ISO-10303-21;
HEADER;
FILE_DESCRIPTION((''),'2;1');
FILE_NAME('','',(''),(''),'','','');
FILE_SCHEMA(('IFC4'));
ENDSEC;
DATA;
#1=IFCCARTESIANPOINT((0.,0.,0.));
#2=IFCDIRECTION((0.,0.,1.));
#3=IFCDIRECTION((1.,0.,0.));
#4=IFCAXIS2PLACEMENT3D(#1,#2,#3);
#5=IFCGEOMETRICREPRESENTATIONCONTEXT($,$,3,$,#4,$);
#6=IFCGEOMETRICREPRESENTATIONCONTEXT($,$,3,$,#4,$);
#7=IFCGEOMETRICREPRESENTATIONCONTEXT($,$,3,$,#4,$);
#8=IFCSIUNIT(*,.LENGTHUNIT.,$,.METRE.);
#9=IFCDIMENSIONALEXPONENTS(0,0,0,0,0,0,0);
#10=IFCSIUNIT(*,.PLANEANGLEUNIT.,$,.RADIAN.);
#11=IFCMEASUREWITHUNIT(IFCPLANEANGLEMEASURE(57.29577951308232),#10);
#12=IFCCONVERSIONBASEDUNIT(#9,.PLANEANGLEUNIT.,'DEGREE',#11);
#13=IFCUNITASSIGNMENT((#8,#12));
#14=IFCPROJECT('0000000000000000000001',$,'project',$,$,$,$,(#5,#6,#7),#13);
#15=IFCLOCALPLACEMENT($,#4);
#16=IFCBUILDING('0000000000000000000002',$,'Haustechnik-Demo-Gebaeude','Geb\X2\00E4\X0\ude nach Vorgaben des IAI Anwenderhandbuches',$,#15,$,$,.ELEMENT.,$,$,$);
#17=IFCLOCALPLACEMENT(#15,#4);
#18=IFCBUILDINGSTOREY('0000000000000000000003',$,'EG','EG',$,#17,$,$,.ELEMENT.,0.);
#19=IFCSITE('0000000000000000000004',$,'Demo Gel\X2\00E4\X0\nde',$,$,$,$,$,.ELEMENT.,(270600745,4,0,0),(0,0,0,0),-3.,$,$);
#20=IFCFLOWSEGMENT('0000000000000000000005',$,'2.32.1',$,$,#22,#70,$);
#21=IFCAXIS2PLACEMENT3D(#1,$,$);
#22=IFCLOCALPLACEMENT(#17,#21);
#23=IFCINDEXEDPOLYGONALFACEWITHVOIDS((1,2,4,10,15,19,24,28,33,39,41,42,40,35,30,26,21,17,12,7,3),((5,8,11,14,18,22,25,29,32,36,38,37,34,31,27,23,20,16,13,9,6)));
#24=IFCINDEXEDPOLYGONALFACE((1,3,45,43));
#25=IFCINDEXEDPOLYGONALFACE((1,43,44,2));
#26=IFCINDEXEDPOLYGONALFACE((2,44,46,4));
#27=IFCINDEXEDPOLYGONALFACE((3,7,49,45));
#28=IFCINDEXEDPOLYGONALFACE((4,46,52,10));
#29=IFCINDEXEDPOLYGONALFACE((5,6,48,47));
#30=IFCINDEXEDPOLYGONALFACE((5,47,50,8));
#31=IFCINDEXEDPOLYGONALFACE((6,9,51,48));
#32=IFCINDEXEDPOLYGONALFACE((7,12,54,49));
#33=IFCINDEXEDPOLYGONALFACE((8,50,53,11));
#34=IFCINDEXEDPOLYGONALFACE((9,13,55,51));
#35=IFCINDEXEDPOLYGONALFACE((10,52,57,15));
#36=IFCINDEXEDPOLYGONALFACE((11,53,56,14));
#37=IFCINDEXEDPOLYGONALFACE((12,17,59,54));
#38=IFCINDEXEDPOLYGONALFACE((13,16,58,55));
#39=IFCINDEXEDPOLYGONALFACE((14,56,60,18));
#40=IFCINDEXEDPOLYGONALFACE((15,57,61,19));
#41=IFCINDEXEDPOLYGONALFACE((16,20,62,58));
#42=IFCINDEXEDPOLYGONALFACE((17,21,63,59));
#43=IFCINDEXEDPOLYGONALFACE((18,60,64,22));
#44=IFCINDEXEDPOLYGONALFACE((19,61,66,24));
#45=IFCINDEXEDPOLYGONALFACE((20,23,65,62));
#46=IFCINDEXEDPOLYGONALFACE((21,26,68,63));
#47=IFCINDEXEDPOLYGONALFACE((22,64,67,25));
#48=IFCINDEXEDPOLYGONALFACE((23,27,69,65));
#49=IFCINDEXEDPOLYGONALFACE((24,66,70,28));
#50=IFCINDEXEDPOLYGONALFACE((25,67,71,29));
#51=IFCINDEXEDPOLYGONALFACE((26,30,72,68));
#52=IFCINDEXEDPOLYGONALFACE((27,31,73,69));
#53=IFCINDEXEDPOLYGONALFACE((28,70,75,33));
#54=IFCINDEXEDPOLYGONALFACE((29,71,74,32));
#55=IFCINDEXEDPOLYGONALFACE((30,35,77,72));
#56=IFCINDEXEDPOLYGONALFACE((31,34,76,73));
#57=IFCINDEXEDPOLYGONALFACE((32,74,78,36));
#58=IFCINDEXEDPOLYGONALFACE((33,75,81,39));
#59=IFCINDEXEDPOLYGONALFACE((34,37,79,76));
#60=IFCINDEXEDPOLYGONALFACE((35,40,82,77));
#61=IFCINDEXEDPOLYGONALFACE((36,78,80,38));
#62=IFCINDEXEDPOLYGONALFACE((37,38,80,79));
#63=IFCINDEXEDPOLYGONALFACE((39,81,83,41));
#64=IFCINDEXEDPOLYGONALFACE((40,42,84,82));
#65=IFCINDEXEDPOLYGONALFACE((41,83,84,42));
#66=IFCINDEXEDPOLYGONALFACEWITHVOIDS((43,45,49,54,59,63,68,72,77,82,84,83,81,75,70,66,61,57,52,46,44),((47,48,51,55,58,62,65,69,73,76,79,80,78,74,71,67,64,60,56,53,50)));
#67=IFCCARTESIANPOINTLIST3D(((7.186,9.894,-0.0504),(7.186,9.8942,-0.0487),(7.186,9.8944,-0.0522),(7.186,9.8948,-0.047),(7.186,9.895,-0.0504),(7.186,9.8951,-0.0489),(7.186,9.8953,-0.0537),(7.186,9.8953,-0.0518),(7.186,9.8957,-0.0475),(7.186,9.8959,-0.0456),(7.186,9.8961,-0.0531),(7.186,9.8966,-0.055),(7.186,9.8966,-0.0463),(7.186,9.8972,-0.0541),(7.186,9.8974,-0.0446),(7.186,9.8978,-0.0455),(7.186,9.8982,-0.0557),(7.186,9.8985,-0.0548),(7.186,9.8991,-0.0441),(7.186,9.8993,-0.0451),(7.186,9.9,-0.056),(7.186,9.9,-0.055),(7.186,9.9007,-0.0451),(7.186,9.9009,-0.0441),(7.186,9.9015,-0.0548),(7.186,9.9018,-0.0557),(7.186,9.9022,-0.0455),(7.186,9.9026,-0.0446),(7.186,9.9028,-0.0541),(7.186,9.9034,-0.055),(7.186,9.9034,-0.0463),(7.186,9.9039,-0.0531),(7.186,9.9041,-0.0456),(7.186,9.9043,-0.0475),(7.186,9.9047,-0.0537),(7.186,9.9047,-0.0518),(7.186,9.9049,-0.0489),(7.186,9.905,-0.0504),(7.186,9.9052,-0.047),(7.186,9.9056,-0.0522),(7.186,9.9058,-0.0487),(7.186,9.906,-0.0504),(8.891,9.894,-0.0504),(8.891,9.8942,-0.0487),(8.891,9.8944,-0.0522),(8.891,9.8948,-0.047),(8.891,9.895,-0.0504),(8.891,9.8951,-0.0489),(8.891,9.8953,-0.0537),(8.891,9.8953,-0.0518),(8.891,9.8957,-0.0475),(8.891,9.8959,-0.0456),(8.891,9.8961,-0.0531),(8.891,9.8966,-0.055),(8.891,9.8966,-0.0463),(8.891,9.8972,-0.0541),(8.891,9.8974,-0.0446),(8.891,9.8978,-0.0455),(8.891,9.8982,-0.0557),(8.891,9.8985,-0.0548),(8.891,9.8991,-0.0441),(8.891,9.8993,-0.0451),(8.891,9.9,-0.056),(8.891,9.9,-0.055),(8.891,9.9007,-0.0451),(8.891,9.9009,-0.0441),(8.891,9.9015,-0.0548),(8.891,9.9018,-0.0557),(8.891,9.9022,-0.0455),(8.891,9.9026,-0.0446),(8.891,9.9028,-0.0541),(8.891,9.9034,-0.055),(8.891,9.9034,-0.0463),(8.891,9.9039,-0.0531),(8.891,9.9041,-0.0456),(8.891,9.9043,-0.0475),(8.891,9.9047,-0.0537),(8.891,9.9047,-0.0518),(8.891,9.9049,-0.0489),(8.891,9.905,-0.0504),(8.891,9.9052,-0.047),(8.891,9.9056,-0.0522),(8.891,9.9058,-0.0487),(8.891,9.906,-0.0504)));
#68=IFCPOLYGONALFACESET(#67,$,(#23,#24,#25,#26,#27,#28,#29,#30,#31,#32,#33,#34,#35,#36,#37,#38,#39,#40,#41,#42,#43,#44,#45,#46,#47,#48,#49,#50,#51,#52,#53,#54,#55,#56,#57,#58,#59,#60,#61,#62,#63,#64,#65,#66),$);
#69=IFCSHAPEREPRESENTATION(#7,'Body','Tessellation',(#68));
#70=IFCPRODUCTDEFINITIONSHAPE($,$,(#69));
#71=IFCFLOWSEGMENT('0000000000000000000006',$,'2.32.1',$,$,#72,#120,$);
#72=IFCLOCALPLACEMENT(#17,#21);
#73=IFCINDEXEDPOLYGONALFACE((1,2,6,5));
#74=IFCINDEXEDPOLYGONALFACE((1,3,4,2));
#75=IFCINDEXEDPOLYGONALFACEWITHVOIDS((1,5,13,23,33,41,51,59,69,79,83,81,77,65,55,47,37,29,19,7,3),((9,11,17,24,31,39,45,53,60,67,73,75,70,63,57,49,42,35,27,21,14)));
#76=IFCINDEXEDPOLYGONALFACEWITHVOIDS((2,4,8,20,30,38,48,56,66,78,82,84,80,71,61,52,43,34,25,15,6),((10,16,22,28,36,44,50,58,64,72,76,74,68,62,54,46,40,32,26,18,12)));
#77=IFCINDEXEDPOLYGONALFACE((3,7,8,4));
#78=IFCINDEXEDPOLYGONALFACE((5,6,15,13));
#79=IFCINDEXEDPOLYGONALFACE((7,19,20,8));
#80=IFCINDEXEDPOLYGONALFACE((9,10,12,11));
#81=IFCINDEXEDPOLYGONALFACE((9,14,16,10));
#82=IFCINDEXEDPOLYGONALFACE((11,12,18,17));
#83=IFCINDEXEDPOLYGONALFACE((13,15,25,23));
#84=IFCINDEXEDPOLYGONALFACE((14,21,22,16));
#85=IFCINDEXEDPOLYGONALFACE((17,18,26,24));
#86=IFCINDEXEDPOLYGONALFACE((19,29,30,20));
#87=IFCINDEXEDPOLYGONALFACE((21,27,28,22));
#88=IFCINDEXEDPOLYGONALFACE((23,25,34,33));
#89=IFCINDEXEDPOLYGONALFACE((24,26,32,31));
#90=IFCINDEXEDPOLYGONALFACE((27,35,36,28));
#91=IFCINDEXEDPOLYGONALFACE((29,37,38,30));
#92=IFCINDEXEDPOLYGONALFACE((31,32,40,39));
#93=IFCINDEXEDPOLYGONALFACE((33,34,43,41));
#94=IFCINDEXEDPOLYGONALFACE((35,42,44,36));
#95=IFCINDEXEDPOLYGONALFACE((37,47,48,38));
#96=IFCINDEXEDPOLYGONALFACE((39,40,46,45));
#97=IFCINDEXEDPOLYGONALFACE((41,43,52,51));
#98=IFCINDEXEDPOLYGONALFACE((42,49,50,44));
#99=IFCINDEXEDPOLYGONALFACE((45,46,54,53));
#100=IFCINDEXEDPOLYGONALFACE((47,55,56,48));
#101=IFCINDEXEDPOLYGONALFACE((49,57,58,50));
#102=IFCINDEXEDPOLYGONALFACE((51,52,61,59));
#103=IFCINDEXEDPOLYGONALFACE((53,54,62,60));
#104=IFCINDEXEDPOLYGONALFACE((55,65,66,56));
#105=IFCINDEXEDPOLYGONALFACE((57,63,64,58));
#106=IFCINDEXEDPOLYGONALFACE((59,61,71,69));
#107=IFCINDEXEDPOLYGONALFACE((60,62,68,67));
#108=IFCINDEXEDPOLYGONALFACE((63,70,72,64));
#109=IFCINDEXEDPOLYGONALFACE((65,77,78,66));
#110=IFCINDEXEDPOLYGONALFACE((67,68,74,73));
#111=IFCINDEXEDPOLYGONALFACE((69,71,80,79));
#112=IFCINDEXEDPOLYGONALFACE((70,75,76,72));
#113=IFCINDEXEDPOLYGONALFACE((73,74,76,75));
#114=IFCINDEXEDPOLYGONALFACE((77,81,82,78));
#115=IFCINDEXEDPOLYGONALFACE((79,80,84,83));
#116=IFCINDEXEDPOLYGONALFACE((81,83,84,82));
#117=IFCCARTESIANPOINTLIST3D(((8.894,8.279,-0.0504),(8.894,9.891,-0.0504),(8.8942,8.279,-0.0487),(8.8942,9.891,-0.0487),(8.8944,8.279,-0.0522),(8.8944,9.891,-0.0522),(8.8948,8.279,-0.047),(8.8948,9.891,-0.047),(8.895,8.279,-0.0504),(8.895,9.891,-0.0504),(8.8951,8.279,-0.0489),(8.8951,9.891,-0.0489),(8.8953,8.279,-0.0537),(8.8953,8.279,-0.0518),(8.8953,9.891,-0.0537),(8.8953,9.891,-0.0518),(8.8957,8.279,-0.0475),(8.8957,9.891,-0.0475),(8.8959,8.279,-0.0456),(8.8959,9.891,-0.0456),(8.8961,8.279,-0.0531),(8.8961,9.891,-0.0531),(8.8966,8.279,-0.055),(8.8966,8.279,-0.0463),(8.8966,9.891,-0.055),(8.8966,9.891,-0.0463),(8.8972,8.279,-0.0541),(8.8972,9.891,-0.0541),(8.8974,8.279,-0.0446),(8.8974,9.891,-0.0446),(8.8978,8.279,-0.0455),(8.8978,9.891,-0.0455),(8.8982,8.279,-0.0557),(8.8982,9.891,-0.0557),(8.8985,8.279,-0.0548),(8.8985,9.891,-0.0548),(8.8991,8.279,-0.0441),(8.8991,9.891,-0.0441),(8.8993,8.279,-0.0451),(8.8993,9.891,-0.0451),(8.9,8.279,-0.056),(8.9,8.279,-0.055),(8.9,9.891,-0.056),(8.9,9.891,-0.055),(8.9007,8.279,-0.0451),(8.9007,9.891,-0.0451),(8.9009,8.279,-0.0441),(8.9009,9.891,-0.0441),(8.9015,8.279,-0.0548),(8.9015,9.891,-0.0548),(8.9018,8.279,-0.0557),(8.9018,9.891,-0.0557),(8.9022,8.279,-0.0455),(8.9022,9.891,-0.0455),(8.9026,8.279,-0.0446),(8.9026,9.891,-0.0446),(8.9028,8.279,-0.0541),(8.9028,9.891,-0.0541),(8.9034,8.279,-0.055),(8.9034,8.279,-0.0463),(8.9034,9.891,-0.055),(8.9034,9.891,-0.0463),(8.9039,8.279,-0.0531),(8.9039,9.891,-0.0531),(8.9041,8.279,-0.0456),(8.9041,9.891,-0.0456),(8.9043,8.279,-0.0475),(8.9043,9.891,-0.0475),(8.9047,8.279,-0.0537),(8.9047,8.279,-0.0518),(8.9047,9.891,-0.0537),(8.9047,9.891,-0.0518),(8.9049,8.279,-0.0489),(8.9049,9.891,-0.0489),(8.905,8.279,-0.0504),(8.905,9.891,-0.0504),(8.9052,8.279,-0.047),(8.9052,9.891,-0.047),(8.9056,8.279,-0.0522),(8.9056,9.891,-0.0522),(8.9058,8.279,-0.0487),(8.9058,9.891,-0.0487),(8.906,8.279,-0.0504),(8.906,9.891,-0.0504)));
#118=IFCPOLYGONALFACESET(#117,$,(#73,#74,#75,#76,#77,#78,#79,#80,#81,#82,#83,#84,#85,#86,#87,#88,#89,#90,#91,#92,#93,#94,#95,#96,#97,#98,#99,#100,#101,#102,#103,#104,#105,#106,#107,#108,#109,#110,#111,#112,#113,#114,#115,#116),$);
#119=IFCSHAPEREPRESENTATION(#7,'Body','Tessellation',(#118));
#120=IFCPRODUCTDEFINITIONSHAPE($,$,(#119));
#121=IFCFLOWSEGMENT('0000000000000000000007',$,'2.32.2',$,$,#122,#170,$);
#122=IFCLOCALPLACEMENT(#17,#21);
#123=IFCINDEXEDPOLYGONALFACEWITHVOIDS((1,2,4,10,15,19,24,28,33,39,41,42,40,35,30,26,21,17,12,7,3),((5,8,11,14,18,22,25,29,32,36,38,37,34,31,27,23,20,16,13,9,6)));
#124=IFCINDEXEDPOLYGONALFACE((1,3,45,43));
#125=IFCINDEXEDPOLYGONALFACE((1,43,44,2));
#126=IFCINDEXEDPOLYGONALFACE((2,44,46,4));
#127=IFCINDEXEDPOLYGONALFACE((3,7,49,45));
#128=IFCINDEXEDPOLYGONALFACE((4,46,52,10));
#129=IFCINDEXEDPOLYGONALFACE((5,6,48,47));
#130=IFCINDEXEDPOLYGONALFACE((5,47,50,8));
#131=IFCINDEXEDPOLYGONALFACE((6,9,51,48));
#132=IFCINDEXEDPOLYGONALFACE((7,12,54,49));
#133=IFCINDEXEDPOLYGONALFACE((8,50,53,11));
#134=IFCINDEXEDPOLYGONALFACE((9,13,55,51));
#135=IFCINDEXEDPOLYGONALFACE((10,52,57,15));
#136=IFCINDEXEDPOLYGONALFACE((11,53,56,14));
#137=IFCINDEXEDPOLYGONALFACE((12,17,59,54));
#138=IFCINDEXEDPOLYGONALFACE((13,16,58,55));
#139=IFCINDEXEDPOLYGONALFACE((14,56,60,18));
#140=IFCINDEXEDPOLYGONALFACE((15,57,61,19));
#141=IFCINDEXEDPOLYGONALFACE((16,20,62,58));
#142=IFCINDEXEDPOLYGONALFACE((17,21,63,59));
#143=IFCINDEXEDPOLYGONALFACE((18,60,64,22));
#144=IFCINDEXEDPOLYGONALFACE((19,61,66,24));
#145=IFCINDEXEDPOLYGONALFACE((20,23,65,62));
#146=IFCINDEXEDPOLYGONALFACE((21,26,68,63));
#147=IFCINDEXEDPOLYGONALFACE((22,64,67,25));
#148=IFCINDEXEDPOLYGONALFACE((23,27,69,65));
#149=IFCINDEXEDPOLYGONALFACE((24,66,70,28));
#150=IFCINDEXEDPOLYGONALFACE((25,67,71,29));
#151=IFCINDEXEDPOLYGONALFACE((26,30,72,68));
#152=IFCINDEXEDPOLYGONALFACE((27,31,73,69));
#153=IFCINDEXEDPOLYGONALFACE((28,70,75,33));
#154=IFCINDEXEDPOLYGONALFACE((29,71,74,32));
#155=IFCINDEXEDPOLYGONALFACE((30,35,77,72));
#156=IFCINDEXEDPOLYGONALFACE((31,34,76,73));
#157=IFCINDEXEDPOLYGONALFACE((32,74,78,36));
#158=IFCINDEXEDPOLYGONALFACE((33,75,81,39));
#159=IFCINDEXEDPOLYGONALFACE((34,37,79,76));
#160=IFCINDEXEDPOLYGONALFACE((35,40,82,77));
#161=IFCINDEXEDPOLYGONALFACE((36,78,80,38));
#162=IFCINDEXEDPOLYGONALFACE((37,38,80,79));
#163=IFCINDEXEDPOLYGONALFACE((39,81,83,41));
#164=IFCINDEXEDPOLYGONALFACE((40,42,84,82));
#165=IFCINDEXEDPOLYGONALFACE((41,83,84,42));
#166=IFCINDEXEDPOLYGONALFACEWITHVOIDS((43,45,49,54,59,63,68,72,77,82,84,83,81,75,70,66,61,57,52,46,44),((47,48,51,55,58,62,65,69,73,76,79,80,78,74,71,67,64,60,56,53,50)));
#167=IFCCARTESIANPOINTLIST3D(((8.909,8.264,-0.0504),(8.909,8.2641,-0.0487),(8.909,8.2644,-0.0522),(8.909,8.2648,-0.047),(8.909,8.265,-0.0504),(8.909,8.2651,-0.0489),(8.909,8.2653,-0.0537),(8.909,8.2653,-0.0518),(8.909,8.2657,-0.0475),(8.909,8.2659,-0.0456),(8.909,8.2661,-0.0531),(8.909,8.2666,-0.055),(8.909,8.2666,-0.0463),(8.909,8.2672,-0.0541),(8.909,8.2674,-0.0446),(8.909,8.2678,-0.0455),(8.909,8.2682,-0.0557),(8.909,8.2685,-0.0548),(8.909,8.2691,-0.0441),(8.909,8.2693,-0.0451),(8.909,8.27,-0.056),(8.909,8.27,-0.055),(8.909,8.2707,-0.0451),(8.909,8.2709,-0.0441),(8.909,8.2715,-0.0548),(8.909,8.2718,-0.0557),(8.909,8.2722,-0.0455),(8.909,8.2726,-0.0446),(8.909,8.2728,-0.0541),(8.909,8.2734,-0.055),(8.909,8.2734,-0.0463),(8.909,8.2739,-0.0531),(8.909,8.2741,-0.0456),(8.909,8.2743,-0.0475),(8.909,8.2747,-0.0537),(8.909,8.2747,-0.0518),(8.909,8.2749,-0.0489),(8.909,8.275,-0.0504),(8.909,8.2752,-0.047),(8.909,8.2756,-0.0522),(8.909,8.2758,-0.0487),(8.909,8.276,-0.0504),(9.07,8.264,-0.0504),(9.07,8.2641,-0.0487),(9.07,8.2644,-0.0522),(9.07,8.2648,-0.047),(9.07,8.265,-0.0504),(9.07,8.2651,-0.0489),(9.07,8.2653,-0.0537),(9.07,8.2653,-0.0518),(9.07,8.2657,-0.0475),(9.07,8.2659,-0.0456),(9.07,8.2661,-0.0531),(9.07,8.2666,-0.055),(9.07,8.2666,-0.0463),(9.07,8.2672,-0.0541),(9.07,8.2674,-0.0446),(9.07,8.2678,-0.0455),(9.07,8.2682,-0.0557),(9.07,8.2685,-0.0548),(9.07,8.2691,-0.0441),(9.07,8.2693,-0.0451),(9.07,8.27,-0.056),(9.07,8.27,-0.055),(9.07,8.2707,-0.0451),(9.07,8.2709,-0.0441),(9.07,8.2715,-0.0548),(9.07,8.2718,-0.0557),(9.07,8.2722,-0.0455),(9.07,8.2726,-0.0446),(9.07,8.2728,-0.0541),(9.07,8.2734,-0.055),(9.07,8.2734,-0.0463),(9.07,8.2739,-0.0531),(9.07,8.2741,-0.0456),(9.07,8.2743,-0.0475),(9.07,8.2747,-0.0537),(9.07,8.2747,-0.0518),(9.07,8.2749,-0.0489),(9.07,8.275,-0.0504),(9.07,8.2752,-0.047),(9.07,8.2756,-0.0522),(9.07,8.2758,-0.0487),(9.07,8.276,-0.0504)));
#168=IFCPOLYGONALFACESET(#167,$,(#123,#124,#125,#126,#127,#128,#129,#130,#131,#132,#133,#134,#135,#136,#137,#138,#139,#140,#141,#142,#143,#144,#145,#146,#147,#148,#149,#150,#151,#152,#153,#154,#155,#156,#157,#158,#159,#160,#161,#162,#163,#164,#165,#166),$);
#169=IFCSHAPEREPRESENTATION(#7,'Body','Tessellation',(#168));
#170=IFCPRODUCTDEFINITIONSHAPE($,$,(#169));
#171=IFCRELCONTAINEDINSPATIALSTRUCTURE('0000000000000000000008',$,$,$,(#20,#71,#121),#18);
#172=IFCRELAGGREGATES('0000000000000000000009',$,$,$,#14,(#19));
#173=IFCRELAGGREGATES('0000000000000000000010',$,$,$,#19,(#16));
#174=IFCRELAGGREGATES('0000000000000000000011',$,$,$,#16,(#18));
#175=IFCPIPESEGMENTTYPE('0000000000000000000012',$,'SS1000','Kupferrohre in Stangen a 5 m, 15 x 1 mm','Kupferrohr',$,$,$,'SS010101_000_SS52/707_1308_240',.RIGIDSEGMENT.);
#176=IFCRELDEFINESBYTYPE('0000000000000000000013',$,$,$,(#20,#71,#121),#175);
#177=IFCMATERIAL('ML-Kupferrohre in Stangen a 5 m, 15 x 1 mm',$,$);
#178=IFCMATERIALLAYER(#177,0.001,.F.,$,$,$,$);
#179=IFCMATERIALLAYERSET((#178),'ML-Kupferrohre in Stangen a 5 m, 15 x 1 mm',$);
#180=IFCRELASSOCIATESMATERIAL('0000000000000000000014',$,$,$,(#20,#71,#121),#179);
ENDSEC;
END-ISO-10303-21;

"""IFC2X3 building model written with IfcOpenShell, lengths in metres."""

from ifc_helpers import new_model, entity, si_unit, converted_unit, frame, origin_with_axes, origin_2d_with_axis, place, context, project, spatial, hollow_circle, extrude, material, layer, layer_set, layer_usage, type_object, element, save


model = new_model("IFC2X3")

# Units and contexts
context_of_model_1 = context(None, 3, world=origin_with_axes())
context_of_model_2 = context(None, 3, world=origin_with_axes())
context_of_model_3 = context(None, 3, world=origin_with_axes())
ifc_project = project(units=[si_unit("LENGTHUNIT", "METRE"), converted_unit("PLANEANGLEUNIT", "DEGREE", entity("IfcPlaneAngleMeasure", 57.29577951308232), si_unit("PLANEANGLEUNIT", "RADIAN"), dimensions=[0, 0, 0, 0, 0, 0, 0])], contexts=[context_of_model_1, context_of_model_2, context_of_model_3])

# Site, building, storey
site = spatial("IfcSite", under=ifc_project, Name="Demo Gelände", CompositionType="ELEMENT", RefLatitude=(270600745, 4, 0, 0), RefLongitude=(0, 0, 0, 0), RefElevation=-3.0)
building_placement = place(None, origin_with_axes())
building = spatial("IfcBuilding", under=site, at=building_placement, Name="Haustechnik-Demo-Gebaeude", Description="Gebäude nach Vorgaben des IAI Anwenderhandbuches", CompositionType="ELEMENT")
storey_placement = place(building_placement, origin_with_axes())
storey = spatial("IfcBuildingStorey", under=building, at=storey_placement, Name="EG", Description="EG", CompositionType="ELEMENT", Elevation=0.0)

# Flow segments
ifc_material_1 = material(Name="ML-Kupferrohre in Stangen a 5 m, 15 x 1 mm")
ifc_layer_1 = layer(ifc_material_1, 0.001, ventilated=False)
ifc_layer_set_1 = layer_set([ifc_layer_1], Name="ML-Kupferrohre in Stangen a 5 m, 15 x 1 mm")
ifc_layer_usage_1 = layer_usage(ifc_layer_set_1, "AXIS2", "POSITIVE", 0.0)
pipe_segment_type_1 = type_object("IfcPipeSegmentType", Name="SS1000", Description="Kupferrohre in Stangen a 5 m, 15 x 1 mm", ApplicableOccurrence="Kupferrohr", ElementType="SS010101_000_SS52/707_1308_240", PredefinedType="RIGIDSEGMENT")
flow_segment_1_placement = place(storey_placement, frame((7.186, 9.9, -0.05), z_axis=(1.0, 0.0, 0.0), x_axis=(0.0, 0.0, -1.0)))
element("IfcFlowSegment", 1, at=flow_segment_1_placement, inside=storey, type_object=pipe_segment_type_1, material=ifc_layer_usage_1, Name="2.32.1", context=context_of_model_3, shape_type="SweptSolid", body=[
    extrude(hollow_circle(Radius=0.006, WallThickness=0.001, at=origin_2d_with_axis()), origin_with_axes(), (0.0, 0.0, 1.0), 1.705),
])
flow_segment_2_placement = place(storey_placement, frame((8.9, 9.891, -0.05), z_axis=(0.0, -1.0, 0.0), x_axis=(0.0, 0.0, -1.0)))
element("IfcFlowSegment", 2, at=flow_segment_2_placement, inside=storey, type_object=pipe_segment_type_1, material=ifc_layer_usage_1, Name="2.32.1", context=context_of_model_3, shape_type="SweptSolid", body=[
    extrude(hollow_circle(Radius=0.006, WallThickness=0.001, at=origin_2d_with_axis()), origin_with_axes(), (0.0, 0.0, 1.0), 1.612),
])
flow_segment_3_placement = place(storey_placement, frame((8.909, 8.27, -0.05), z_axis=(1.0, 0.0, 0.0), x_axis=(0.0, 0.0, -1.0)))
element("IfcFlowSegment", 3, at=flow_segment_3_placement, inside=storey, type_object=pipe_segment_type_1, material=ifc_layer_usage_1, Name="2.32.2", context=context_of_model_3, shape_type="SweptSolid", body=[
    extrude(hollow_circle(Radius=0.006, WallThickness=0.001, at=origin_2d_with_axis()), origin_with_axes(), (0.0, 0.0, 1.0), 0.161),
])

save(model, "model.ifc")
